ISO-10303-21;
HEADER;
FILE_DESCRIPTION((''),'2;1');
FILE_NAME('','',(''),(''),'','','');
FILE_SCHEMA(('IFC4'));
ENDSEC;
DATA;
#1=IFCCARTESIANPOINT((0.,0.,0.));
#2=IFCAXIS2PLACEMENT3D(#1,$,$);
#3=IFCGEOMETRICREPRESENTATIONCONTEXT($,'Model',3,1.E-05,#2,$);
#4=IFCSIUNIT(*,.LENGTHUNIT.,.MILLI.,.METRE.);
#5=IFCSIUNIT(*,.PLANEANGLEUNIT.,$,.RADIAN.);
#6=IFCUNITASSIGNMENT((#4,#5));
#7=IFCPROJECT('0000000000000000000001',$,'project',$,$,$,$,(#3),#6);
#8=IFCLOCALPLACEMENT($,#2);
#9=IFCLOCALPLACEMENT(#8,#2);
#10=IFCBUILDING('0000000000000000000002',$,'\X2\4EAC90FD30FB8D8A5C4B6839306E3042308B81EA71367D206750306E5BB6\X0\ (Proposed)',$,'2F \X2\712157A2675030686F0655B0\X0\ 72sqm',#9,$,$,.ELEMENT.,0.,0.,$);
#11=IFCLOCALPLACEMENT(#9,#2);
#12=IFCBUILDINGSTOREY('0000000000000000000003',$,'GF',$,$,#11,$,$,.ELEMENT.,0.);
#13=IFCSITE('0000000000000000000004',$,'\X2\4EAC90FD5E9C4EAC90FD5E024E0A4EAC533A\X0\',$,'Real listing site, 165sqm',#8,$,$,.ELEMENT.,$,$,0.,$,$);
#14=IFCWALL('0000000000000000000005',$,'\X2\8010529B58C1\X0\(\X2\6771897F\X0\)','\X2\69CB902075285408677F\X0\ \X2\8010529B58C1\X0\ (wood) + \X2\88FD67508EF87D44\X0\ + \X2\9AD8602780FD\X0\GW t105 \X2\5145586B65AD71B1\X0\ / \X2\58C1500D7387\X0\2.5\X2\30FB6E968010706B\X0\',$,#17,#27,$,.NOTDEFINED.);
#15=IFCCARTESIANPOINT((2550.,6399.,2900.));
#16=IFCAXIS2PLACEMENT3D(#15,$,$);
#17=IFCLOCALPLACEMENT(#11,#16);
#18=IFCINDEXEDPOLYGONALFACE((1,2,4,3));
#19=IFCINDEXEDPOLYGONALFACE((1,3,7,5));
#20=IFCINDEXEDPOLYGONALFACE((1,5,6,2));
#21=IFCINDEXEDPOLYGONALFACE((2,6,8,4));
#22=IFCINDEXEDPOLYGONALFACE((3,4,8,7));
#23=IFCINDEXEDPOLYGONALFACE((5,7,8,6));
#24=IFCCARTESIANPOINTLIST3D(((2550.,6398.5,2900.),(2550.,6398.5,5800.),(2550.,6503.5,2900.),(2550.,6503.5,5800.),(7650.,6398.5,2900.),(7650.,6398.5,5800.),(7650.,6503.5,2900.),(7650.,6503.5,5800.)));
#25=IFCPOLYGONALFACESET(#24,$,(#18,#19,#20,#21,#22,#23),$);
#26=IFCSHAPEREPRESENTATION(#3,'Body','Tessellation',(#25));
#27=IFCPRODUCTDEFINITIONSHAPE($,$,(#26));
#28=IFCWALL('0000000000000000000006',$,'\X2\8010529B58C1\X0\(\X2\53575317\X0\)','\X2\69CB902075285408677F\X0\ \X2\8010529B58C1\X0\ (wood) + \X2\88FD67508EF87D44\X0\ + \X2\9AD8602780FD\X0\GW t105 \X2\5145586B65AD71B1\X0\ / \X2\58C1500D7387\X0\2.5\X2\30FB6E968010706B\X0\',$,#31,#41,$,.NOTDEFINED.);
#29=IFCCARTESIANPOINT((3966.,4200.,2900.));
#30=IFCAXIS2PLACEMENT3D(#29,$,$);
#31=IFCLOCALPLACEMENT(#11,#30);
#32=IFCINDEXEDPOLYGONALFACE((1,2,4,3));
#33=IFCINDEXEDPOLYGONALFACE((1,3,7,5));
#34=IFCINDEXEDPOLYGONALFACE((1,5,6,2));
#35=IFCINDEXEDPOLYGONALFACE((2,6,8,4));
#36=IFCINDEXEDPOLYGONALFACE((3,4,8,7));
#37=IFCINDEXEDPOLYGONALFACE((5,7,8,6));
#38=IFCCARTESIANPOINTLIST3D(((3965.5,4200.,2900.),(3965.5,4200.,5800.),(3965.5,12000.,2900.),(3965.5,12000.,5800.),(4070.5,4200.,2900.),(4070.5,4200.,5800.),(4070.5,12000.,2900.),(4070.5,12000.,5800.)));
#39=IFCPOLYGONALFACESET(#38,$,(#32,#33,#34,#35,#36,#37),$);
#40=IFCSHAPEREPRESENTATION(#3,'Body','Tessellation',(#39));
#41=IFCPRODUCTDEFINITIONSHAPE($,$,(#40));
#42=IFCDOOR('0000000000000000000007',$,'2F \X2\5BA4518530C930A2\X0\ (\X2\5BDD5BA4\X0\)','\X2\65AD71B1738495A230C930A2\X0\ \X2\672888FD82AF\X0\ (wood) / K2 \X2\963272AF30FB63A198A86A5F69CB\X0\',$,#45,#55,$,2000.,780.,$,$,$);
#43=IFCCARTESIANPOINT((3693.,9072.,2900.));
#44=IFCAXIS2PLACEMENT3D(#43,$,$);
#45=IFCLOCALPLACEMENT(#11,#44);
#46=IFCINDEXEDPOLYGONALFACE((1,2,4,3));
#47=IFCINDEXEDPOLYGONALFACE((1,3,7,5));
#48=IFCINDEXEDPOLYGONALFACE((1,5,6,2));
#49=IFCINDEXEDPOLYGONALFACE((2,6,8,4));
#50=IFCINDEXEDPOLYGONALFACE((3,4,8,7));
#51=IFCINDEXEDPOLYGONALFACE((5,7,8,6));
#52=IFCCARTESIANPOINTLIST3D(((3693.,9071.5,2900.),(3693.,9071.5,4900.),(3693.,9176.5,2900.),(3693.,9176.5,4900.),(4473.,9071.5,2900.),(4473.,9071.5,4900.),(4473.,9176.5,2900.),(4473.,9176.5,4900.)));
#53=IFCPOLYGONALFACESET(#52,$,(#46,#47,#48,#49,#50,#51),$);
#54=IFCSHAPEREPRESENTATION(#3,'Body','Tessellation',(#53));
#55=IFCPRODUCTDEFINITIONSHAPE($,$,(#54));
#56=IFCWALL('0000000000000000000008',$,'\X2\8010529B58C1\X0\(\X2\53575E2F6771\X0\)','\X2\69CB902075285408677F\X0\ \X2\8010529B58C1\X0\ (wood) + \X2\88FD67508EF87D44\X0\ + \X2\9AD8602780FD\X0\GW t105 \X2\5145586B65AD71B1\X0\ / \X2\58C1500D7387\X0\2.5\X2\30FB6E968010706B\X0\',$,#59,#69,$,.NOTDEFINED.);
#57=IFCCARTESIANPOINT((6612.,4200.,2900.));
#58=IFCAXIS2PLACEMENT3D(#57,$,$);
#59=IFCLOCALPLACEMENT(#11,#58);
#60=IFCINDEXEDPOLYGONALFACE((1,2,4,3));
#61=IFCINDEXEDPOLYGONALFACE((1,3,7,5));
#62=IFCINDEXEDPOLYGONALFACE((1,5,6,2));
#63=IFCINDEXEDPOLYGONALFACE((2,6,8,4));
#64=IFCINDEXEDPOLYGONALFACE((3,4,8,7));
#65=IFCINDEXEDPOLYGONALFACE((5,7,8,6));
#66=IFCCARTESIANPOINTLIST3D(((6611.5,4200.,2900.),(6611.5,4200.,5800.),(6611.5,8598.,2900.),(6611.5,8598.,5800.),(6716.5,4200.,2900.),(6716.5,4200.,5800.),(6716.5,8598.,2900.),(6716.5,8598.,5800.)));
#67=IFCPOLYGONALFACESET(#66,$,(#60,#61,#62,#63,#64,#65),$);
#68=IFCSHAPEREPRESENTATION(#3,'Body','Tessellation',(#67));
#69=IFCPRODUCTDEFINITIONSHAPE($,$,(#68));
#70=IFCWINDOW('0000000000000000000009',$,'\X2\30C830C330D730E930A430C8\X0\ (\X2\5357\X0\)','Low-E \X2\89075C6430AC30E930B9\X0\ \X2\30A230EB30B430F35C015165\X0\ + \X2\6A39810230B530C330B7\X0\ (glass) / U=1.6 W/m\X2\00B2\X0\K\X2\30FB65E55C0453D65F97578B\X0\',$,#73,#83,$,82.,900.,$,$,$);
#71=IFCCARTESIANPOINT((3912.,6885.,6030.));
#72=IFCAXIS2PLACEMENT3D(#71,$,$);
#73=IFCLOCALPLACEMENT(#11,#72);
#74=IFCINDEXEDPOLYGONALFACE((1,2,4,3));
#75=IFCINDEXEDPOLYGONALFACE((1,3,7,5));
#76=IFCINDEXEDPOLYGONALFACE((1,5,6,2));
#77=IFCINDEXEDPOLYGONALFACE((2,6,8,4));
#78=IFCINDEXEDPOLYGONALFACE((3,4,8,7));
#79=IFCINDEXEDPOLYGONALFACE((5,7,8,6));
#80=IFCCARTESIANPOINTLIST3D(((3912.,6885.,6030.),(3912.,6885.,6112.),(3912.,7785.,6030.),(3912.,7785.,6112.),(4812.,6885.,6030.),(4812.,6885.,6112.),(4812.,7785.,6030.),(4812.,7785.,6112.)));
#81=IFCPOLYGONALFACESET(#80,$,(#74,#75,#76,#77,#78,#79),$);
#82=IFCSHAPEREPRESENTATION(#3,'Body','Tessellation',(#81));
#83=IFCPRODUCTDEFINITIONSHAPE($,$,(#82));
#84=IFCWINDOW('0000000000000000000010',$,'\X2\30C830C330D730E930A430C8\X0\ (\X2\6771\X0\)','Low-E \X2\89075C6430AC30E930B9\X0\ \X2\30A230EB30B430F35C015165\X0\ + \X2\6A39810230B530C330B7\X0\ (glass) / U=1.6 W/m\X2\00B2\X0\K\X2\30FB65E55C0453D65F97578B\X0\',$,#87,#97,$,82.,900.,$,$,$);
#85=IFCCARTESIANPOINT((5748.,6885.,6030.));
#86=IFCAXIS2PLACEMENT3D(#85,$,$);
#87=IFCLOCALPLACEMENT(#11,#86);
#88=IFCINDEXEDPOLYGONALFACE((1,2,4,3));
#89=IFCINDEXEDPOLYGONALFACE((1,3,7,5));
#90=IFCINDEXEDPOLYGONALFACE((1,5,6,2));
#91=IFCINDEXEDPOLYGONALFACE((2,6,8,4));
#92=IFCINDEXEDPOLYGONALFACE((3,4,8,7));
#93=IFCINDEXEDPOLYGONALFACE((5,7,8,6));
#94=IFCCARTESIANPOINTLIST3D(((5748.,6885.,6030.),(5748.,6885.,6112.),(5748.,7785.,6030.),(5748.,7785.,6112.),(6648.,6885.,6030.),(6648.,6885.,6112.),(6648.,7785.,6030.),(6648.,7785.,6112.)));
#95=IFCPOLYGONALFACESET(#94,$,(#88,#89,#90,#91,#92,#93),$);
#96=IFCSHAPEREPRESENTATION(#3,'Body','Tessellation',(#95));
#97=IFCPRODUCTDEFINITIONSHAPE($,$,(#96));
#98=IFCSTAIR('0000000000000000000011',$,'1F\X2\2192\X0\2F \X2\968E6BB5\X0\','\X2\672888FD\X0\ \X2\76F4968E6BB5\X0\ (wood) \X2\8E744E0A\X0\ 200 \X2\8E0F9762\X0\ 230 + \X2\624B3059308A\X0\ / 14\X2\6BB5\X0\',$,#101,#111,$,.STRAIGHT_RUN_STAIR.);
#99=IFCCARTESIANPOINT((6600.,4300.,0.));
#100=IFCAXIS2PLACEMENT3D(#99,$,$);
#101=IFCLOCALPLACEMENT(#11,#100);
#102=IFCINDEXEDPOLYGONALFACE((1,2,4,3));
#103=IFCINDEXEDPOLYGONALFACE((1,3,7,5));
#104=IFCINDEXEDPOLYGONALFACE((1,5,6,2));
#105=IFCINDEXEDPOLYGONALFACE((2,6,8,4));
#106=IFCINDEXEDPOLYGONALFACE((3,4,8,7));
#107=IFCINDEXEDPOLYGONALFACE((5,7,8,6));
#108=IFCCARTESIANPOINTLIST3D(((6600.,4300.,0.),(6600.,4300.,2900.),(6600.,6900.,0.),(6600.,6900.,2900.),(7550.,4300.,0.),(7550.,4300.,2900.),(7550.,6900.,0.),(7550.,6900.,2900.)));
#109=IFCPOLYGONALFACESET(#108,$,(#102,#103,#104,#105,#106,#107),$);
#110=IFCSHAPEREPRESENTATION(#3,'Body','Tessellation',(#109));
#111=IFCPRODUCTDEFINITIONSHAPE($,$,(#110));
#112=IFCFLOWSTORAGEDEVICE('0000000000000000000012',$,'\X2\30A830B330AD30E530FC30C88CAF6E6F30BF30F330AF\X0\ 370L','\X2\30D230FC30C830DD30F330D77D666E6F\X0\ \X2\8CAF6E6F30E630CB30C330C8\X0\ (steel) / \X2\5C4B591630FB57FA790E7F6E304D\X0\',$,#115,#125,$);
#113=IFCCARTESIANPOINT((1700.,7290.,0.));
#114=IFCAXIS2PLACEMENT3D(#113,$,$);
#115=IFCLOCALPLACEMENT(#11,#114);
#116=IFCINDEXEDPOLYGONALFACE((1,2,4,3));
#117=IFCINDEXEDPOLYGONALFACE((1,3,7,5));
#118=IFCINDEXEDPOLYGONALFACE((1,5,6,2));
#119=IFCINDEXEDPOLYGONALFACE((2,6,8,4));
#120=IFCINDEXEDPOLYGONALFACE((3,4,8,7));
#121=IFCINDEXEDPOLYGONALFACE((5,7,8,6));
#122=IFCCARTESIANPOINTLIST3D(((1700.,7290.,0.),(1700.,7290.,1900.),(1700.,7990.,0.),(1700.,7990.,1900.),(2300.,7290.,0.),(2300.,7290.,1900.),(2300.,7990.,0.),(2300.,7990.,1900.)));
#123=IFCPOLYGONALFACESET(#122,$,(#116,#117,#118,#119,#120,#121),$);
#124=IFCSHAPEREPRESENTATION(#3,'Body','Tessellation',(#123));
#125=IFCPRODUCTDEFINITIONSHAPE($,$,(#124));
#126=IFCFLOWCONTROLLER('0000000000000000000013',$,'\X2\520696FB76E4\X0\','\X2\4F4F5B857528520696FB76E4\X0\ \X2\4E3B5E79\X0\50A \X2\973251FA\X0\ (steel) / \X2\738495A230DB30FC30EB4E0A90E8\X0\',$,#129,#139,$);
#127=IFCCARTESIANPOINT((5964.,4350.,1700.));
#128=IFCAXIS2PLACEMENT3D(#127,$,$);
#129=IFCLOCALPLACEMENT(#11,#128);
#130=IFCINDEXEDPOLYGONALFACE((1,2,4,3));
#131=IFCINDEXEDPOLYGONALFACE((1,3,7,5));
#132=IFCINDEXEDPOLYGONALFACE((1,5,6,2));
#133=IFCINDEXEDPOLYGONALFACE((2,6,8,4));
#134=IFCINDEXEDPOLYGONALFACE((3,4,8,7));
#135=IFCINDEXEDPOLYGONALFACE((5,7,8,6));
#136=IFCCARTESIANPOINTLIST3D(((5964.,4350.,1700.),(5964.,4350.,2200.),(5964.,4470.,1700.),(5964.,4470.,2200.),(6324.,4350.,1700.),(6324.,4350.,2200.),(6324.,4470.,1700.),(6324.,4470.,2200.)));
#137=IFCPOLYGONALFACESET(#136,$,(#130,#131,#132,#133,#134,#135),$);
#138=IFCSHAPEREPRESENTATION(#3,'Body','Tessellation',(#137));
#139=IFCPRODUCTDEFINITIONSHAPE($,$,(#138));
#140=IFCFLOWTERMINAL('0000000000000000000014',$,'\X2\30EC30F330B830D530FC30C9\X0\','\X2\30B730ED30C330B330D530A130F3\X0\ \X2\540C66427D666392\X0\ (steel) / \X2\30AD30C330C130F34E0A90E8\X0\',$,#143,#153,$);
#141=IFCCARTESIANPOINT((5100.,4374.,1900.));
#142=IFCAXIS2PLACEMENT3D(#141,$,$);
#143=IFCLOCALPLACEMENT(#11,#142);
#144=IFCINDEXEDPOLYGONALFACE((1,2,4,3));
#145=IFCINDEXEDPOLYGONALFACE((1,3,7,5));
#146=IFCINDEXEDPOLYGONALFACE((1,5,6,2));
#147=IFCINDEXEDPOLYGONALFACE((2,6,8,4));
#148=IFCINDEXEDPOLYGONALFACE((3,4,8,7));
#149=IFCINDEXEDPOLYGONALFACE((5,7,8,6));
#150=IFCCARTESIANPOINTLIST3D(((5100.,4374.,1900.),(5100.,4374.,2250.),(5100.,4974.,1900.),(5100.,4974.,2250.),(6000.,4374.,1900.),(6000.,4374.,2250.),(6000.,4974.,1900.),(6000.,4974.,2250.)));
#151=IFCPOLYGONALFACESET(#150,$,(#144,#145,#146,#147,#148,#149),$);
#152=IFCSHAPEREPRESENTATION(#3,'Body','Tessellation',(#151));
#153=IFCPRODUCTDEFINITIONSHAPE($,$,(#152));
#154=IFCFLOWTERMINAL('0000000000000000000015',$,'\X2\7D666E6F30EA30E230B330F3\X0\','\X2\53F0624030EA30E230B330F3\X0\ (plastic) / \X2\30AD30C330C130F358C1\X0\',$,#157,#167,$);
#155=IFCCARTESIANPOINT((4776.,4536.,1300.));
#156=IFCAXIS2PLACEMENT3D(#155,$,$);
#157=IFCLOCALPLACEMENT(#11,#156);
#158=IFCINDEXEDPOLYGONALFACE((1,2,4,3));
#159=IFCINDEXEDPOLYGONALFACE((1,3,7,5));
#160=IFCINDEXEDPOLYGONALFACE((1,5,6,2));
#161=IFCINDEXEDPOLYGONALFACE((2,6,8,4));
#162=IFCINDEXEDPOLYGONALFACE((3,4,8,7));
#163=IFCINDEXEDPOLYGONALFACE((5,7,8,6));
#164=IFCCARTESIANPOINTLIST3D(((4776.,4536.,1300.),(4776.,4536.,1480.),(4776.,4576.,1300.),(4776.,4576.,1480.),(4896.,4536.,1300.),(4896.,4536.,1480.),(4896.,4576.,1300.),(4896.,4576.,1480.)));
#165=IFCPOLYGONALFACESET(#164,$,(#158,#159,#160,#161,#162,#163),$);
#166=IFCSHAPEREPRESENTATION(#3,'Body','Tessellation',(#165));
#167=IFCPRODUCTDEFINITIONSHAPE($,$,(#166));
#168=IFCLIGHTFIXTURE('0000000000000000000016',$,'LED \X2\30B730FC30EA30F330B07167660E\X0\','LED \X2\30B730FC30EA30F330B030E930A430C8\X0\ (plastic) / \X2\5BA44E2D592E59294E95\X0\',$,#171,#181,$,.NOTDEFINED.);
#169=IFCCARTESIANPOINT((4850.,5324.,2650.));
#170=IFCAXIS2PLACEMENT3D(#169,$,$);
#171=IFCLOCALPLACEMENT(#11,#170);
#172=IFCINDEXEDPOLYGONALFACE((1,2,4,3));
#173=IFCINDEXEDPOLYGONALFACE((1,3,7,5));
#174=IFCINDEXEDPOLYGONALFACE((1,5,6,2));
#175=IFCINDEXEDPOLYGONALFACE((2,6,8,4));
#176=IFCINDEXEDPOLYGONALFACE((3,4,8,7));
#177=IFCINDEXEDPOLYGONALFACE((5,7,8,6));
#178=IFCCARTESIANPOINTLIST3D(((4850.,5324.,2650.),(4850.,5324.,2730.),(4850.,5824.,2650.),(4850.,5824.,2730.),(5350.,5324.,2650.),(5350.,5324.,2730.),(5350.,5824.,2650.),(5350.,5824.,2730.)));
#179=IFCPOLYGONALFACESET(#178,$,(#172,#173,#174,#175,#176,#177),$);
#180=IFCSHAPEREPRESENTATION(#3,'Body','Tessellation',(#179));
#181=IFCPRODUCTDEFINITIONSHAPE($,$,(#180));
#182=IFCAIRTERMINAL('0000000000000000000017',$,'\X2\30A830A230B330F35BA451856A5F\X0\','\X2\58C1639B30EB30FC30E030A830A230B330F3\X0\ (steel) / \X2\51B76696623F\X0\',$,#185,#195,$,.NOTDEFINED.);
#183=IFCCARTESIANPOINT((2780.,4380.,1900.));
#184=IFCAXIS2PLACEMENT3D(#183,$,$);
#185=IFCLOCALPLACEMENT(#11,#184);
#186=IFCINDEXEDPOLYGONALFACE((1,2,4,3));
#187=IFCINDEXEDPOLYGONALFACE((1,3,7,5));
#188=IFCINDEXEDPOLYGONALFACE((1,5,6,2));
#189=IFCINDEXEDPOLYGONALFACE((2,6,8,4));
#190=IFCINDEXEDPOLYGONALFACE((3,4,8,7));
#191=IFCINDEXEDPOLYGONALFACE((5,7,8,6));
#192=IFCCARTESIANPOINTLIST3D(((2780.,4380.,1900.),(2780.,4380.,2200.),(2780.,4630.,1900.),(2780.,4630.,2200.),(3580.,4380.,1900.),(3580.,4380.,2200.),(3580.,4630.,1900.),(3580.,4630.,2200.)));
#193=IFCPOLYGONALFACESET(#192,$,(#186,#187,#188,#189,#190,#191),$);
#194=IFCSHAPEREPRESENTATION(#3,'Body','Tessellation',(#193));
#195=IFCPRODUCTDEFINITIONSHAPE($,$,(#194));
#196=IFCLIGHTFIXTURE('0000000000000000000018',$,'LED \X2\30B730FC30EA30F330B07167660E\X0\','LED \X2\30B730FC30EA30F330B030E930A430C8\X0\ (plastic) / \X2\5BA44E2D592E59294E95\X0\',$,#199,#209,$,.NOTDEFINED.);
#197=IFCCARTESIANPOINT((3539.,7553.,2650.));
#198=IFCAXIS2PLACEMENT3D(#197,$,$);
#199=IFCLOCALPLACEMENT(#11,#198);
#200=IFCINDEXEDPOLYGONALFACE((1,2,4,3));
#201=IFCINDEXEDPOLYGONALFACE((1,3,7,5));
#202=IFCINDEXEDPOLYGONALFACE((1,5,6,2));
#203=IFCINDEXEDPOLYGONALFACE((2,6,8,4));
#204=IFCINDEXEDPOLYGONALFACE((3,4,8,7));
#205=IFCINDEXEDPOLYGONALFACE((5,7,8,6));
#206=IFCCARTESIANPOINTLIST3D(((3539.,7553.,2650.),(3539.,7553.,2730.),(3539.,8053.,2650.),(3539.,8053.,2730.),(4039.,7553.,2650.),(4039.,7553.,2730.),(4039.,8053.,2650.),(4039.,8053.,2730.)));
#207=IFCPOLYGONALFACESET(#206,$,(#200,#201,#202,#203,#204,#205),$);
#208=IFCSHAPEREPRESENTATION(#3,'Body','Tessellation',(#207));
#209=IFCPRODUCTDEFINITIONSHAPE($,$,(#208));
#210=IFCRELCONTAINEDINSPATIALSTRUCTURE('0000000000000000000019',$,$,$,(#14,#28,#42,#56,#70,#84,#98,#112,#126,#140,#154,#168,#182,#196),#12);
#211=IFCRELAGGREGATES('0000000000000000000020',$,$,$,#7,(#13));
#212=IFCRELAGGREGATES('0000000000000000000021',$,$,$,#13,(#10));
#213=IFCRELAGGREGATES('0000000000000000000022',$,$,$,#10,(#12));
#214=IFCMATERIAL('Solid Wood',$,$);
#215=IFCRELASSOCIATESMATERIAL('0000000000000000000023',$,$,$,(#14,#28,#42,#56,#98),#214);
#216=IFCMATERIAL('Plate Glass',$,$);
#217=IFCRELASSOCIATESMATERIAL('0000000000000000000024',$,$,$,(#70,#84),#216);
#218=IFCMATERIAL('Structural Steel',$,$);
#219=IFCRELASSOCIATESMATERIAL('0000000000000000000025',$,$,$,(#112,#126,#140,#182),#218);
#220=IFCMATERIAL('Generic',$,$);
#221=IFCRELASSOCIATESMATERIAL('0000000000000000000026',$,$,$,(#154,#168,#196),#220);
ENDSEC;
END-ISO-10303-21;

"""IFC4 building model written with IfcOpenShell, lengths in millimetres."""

from ifc_helpers import new_model, si_unit, frame, frame_2d, origin, place, context, project, spatial, rectangle, extrude, material, element, fill, save


model = new_model("IFC4")

# Units and contexts
model_context = context("Model", 3, precision=1e-05, world=origin())
ifc_project = project(units=[si_unit("LENGTHUNIT", "METRE", prefix="MILLI"), si_unit("PLANEANGLEUNIT", "RADIAN")], contexts=[model_context])

# Site, building, storey
site_placement = place(None, origin())
site = spatial("IfcSite", under=ifc_project, at=site_placement, Name="京都府京都市上京区", ObjectType="Real listing site, 165sqm", CompositionType="ELEMENT", RefElevation=0.0)
building_placement = place(site_placement, origin())
building = spatial("IfcBuilding", under=site, at=building_placement, Name="京都・越屋根のある自然素材の家 (Proposed)", ObjectType="2F 無垢材と漆喰 72sqm", CompositionType="ELEMENT", ElevationOfRefHeight=0.0, ElevationOfTerrain=0.0)
storey_placement = place(building_placement, origin())
storey = spatial("IfcBuildingStorey", under=building, at=storey_placement, Name="GF", CompositionType="ELEMENT", Elevation=0.0)

# Shared definitions
ifc_material_1 = material(Name="Solid Wood")

# Wall
wall_1_placement = place(storey_placement, frame((2550.0, 6399.0, 2900.0)))
element("IfcWall", 1, at=wall_1_placement, inside=storey, material=ifc_material_1, Name="耐力壁(東西)", Description="構造用合板 耐力壁 (wood) + 製材軸組 + 高性能GW t105 充填断熱 / 壁倍率2.5・準耐火", PredefinedType="NOTDEFINED", context=model_context, shape_type="SweptSolid", body=[
    extrude(rectangle(XDim=5100.0, YDim=105.0, at=frame_2d((2550.0, 52.0))), frame((2550.0, 6399.0, 2900.0)), (0.0, 0.0, 1.0), 2900.0),
])

# Wall, opening, door
wall_2_placement = place(storey_placement, frame((3966.0, 4200.0, 2900.0)))
wall_2 = element("IfcWall", 2, at=wall_2_placement, inside=storey, material=ifc_material_1, Name="耐力壁(南北)", Description="構造用合板 耐力壁 (wood) + 製材軸組 + 高性能GW t105 充填断熱 / 壁倍率2.5・準耐火", PredefinedType="NOTDEFINED", context=model_context, shape_type="SweptSolid", body=[
    extrude(rectangle(XDim=105.0, YDim=7800.0, at=frame_2d((52.0, 3900.0))), frame((3966.0, 4200.0, 2900.0)), (0.0, 0.0, 1.0), 2900.0),
])
opening_placement = place(storey_placement, frame((3693.0, 9072.0, 2900.0)))
opening = element("IfcOpeningElement", 3, at=opening_placement, cuts=wall_2, PredefinedType="NOTDEFINED", context=model_context, shape_type="SweptSolid", body=[
    extrude(rectangle(XDim=780.0, YDim=105.0, at=frame_2d((390.0, 52.0))), frame((3693.0, 9072.0, 2900.0)), (0.0, 0.0, 1.0), 2000.0),
])
door_placement = place(storey_placement, frame((3693.0, 9072.0, 2900.0)))
door = element("IfcDoor", 4, at=door_placement, inside=storey, material=ifc_material_1, Name="2F 室内ドア (寝室)", Description="断熱玄関ドア 木製芯 (wood) / K2 防犯・採風機構", OverallHeight=2000.0, OverallWidth=780.0, context=model_context, shape_type="SweptSolid", body=[
    extrude(rectangle(XDim=780.0, YDim=105.0, at=frame_2d((390.0, 52.0))), frame((3693.0, 9072.0, 2900.0)), (0.0, 0.0, 1.0), 2000.0),
])
fill(opening, door)

# Wall
wall_3_placement = place(storey_placement, frame((6612.0, 4200.0, 2900.0)))
element("IfcWall", 5, at=wall_3_placement, inside=storey, material=ifc_material_1, Name="耐力壁(南帯東)", Description="構造用合板 耐力壁 (wood) + 製材軸組 + 高性能GW t105 充填断熱 / 壁倍率2.5・準耐火", PredefinedType="NOTDEFINED", context=model_context, shape_type="SweptSolid", body=[
    extrude(rectangle(XDim=105.0, YDim=4398.0, at=frame_2d((52.0, 2199.0))), frame((6612.0, 4200.0, 2900.0)), (0.0, 0.0, 1.0), 2900.0),
])

# Windows
ifc_material_2 = material(Name="Plate Glass")
window_1_placement = place(storey_placement, frame((3912.0, 6885.0, 6030.0)))
element("IfcWindow", 6, at=window_1_placement, inside=storey, material=ifc_material_2, Name="トップライト (南)", Description="Low-E 複層ガラス アルゴン封入 + 樹脂サッシ (glass) / U=1.6 W/m²K・日射取得型", OverallHeight=82.0, OverallWidth=900.0, context=model_context, shape_type="SweptSolid", body=[
    extrude(rectangle(XDim=900.0, YDim=900.0, at=frame_2d((450.0, 450.0))), frame((3912.0, 6885.0, 6030.0)), (0.0, 0.0, 1.0), 82.0),
])
window_2_placement = place(storey_placement, frame((5748.0, 6885.0, 6030.0)))
element("IfcWindow", 7, at=window_2_placement, inside=storey, material=ifc_material_2, Name="トップライト (東)", Description="Low-E 複層ガラス アルゴン封入 + 樹脂サッシ (glass) / U=1.6 W/m²K・日射取得型", OverallHeight=82.0, OverallWidth=900.0, context=model_context, shape_type="SweptSolid", body=[
    extrude(rectangle(XDim=900.0, YDim=900.0, at=frame_2d((450.0, 450.0))), frame((5748.0, 6885.0, 6030.0)), (0.0, 0.0, 1.0), 82.0),
])

# Stair
stair_placement = place(storey_placement, frame((6600.0, 4300.0, 0.0)))
element("IfcStair", 8, at=stair_placement, inside=storey, material=ifc_material_1, Name="1F→2F 階段", Description="木製 直階段 (wood) 蹴上 200 踏面 230 + 手すり / 14段", PredefinedType="STRAIGHT_RUN_STAIR", context=model_context, shape_type="SweptSolid", body=[
    extrude(rectangle(XDim=950.0, YDim=2600.0, at=frame_2d((475.0, 1300.0))), frame((6600.0, 4300.0, 0.0)), (0.0, 0.0, 1.0), 2900.0),
])

# Flow storage device
ifc_material_3 = material(Name="Structural Steel")
flow_storage_device_placement = place(storey_placement, frame((1700.0, 7290.0, 0.0)))
element("IfcFlowStorageDevice", 9, at=flow_storage_device_placement, inside=storey, material=ifc_material_3, Name="エコキュート貯湯タンク 370L", Description="ヒートポンプ給湯 貯湯ユニット (steel) / 屋外・基礎置き", context=model_context, shape_type="SweptSolid", body=[
    extrude(rectangle(XDim=600.0, YDim=700.0, at=frame_2d((300.0, 350.0))), frame((1700.0, 7290.0, 0.0)), (0.0, 0.0, 1.0), 1900.0),
])

# Flow controller
flow_controller_placement = place(storey_placement, frame((5964.0, 4350.0, 1700.0)))
element("IfcFlowController", 10, at=flow_controller_placement, inside=storey, material=ifc_material_3, Name="分電盤", Description="住宅用分電盤 主幹50A 露出 (steel) / 玄関ホール上部", context=model_context, shape_type="SweptSolid", body=[
    extrude(rectangle(XDim=360.0, YDim=120.0, at=frame_2d((180.0, 60.0))), frame((5964.0, 4350.0, 1700.0)), (0.0, 0.0, 1.0), 500.0),
])

# Flow terminals
flow_terminal_1_placement = place(storey_placement, frame((5100.0, 4374.0, 1900.0)))
element("IfcFlowTerminal", 11, at=flow_terminal_1_placement, inside=storey, material=ifc_material_3, Name="レンジフード", Description="シロッコファン 同時給排 (steel) / キッチン上部", context=model_context, shape_type="SweptSolid", body=[
    extrude(rectangle(XDim=900.0, YDim=600.0, at=frame_2d((450.0, 300.0))), frame((5100.0, 4374.0, 1900.0)), (0.0, 0.0, 1.0), 350.0),
])
ifc_material_4 = material(Name="Generic")
flow_terminal_2_placement = place(storey_placement, frame((4776.0, 4536.0, 1300.0)))
element("IfcFlowTerminal", 12, at=flow_terminal_2_placement, inside=storey, material=ifc_material_4, Name="給湯リモコン", Description="台所リモコン (plastic) / キッチン壁", context=model_context, shape_type="SweptSolid", body=[
    extrude(rectangle(XDim=120.0, YDim=40.0, at=frame_2d((60.0, 20.0))), frame((4776.0, 4536.0, 1300.0)), (0.0, 0.0, 1.0), 180.0),
])

# Light fixture
light_fixture_1_placement = place(storey_placement, frame((4850.0, 5324.0, 2650.0)))
element("IfcLightFixture", 13, at=light_fixture_1_placement, inside=storey, material=ifc_material_4, Name="LED シーリング照明", Description="LED シーリングライト (plastic) / 室中央天井", PredefinedType="NOTDEFINED", context=model_context, shape_type="SweptSolid", body=[
    extrude(rectangle(XDim=500.0, YDim=500.0, at=frame_2d((250.0, 250.0))), frame((4850.0, 5324.0, 2650.0)), (0.0, 0.0, 1.0), 80.0),
])

# Air terminal
air_terminal_1_placement = place(storey_placement, frame((2780.0, 4380.0, 1900.0)))
element("IfcAirTerminal", 14, at=air_terminal_1_placement, inside=storey, material=ifc_material_3, Name="エアコン室内機", Description="壁掛ルームエアコン (steel) / 冷暖房", PredefinedType="NOTDEFINED", context=model_context, shape_type="SweptSolid", body=[
    extrude(rectangle(XDim=800.0, YDim=250.0, at=frame_2d((400.0, 125.0))), frame((2780.0, 4380.0, 1900.0)), (0.0, 0.0, 1.0), 300.0),
])

# Light fixture
light_fixture_2_placement = place(storey_placement, frame((3539.0, 7553.0, 2650.0)))
element("IfcLightFixture", 15, at=light_fixture_2_placement, inside=storey, material=ifc_material_4, Name="LED シーリング照明", Description="LED シーリングライト (plastic) / 室中央天井", PredefinedType="NOTDEFINED", context=model_context, shape_type="SweptSolid", body=[
    extrude(rectangle(XDim=500.0, YDim=500.0, at=frame_2d((250.0, 250.0))), frame((3539.0, 7553.0, 2650.0)), (0.0, 0.0, 1.0), 80.0),
])

save(model, "model.ifc")
